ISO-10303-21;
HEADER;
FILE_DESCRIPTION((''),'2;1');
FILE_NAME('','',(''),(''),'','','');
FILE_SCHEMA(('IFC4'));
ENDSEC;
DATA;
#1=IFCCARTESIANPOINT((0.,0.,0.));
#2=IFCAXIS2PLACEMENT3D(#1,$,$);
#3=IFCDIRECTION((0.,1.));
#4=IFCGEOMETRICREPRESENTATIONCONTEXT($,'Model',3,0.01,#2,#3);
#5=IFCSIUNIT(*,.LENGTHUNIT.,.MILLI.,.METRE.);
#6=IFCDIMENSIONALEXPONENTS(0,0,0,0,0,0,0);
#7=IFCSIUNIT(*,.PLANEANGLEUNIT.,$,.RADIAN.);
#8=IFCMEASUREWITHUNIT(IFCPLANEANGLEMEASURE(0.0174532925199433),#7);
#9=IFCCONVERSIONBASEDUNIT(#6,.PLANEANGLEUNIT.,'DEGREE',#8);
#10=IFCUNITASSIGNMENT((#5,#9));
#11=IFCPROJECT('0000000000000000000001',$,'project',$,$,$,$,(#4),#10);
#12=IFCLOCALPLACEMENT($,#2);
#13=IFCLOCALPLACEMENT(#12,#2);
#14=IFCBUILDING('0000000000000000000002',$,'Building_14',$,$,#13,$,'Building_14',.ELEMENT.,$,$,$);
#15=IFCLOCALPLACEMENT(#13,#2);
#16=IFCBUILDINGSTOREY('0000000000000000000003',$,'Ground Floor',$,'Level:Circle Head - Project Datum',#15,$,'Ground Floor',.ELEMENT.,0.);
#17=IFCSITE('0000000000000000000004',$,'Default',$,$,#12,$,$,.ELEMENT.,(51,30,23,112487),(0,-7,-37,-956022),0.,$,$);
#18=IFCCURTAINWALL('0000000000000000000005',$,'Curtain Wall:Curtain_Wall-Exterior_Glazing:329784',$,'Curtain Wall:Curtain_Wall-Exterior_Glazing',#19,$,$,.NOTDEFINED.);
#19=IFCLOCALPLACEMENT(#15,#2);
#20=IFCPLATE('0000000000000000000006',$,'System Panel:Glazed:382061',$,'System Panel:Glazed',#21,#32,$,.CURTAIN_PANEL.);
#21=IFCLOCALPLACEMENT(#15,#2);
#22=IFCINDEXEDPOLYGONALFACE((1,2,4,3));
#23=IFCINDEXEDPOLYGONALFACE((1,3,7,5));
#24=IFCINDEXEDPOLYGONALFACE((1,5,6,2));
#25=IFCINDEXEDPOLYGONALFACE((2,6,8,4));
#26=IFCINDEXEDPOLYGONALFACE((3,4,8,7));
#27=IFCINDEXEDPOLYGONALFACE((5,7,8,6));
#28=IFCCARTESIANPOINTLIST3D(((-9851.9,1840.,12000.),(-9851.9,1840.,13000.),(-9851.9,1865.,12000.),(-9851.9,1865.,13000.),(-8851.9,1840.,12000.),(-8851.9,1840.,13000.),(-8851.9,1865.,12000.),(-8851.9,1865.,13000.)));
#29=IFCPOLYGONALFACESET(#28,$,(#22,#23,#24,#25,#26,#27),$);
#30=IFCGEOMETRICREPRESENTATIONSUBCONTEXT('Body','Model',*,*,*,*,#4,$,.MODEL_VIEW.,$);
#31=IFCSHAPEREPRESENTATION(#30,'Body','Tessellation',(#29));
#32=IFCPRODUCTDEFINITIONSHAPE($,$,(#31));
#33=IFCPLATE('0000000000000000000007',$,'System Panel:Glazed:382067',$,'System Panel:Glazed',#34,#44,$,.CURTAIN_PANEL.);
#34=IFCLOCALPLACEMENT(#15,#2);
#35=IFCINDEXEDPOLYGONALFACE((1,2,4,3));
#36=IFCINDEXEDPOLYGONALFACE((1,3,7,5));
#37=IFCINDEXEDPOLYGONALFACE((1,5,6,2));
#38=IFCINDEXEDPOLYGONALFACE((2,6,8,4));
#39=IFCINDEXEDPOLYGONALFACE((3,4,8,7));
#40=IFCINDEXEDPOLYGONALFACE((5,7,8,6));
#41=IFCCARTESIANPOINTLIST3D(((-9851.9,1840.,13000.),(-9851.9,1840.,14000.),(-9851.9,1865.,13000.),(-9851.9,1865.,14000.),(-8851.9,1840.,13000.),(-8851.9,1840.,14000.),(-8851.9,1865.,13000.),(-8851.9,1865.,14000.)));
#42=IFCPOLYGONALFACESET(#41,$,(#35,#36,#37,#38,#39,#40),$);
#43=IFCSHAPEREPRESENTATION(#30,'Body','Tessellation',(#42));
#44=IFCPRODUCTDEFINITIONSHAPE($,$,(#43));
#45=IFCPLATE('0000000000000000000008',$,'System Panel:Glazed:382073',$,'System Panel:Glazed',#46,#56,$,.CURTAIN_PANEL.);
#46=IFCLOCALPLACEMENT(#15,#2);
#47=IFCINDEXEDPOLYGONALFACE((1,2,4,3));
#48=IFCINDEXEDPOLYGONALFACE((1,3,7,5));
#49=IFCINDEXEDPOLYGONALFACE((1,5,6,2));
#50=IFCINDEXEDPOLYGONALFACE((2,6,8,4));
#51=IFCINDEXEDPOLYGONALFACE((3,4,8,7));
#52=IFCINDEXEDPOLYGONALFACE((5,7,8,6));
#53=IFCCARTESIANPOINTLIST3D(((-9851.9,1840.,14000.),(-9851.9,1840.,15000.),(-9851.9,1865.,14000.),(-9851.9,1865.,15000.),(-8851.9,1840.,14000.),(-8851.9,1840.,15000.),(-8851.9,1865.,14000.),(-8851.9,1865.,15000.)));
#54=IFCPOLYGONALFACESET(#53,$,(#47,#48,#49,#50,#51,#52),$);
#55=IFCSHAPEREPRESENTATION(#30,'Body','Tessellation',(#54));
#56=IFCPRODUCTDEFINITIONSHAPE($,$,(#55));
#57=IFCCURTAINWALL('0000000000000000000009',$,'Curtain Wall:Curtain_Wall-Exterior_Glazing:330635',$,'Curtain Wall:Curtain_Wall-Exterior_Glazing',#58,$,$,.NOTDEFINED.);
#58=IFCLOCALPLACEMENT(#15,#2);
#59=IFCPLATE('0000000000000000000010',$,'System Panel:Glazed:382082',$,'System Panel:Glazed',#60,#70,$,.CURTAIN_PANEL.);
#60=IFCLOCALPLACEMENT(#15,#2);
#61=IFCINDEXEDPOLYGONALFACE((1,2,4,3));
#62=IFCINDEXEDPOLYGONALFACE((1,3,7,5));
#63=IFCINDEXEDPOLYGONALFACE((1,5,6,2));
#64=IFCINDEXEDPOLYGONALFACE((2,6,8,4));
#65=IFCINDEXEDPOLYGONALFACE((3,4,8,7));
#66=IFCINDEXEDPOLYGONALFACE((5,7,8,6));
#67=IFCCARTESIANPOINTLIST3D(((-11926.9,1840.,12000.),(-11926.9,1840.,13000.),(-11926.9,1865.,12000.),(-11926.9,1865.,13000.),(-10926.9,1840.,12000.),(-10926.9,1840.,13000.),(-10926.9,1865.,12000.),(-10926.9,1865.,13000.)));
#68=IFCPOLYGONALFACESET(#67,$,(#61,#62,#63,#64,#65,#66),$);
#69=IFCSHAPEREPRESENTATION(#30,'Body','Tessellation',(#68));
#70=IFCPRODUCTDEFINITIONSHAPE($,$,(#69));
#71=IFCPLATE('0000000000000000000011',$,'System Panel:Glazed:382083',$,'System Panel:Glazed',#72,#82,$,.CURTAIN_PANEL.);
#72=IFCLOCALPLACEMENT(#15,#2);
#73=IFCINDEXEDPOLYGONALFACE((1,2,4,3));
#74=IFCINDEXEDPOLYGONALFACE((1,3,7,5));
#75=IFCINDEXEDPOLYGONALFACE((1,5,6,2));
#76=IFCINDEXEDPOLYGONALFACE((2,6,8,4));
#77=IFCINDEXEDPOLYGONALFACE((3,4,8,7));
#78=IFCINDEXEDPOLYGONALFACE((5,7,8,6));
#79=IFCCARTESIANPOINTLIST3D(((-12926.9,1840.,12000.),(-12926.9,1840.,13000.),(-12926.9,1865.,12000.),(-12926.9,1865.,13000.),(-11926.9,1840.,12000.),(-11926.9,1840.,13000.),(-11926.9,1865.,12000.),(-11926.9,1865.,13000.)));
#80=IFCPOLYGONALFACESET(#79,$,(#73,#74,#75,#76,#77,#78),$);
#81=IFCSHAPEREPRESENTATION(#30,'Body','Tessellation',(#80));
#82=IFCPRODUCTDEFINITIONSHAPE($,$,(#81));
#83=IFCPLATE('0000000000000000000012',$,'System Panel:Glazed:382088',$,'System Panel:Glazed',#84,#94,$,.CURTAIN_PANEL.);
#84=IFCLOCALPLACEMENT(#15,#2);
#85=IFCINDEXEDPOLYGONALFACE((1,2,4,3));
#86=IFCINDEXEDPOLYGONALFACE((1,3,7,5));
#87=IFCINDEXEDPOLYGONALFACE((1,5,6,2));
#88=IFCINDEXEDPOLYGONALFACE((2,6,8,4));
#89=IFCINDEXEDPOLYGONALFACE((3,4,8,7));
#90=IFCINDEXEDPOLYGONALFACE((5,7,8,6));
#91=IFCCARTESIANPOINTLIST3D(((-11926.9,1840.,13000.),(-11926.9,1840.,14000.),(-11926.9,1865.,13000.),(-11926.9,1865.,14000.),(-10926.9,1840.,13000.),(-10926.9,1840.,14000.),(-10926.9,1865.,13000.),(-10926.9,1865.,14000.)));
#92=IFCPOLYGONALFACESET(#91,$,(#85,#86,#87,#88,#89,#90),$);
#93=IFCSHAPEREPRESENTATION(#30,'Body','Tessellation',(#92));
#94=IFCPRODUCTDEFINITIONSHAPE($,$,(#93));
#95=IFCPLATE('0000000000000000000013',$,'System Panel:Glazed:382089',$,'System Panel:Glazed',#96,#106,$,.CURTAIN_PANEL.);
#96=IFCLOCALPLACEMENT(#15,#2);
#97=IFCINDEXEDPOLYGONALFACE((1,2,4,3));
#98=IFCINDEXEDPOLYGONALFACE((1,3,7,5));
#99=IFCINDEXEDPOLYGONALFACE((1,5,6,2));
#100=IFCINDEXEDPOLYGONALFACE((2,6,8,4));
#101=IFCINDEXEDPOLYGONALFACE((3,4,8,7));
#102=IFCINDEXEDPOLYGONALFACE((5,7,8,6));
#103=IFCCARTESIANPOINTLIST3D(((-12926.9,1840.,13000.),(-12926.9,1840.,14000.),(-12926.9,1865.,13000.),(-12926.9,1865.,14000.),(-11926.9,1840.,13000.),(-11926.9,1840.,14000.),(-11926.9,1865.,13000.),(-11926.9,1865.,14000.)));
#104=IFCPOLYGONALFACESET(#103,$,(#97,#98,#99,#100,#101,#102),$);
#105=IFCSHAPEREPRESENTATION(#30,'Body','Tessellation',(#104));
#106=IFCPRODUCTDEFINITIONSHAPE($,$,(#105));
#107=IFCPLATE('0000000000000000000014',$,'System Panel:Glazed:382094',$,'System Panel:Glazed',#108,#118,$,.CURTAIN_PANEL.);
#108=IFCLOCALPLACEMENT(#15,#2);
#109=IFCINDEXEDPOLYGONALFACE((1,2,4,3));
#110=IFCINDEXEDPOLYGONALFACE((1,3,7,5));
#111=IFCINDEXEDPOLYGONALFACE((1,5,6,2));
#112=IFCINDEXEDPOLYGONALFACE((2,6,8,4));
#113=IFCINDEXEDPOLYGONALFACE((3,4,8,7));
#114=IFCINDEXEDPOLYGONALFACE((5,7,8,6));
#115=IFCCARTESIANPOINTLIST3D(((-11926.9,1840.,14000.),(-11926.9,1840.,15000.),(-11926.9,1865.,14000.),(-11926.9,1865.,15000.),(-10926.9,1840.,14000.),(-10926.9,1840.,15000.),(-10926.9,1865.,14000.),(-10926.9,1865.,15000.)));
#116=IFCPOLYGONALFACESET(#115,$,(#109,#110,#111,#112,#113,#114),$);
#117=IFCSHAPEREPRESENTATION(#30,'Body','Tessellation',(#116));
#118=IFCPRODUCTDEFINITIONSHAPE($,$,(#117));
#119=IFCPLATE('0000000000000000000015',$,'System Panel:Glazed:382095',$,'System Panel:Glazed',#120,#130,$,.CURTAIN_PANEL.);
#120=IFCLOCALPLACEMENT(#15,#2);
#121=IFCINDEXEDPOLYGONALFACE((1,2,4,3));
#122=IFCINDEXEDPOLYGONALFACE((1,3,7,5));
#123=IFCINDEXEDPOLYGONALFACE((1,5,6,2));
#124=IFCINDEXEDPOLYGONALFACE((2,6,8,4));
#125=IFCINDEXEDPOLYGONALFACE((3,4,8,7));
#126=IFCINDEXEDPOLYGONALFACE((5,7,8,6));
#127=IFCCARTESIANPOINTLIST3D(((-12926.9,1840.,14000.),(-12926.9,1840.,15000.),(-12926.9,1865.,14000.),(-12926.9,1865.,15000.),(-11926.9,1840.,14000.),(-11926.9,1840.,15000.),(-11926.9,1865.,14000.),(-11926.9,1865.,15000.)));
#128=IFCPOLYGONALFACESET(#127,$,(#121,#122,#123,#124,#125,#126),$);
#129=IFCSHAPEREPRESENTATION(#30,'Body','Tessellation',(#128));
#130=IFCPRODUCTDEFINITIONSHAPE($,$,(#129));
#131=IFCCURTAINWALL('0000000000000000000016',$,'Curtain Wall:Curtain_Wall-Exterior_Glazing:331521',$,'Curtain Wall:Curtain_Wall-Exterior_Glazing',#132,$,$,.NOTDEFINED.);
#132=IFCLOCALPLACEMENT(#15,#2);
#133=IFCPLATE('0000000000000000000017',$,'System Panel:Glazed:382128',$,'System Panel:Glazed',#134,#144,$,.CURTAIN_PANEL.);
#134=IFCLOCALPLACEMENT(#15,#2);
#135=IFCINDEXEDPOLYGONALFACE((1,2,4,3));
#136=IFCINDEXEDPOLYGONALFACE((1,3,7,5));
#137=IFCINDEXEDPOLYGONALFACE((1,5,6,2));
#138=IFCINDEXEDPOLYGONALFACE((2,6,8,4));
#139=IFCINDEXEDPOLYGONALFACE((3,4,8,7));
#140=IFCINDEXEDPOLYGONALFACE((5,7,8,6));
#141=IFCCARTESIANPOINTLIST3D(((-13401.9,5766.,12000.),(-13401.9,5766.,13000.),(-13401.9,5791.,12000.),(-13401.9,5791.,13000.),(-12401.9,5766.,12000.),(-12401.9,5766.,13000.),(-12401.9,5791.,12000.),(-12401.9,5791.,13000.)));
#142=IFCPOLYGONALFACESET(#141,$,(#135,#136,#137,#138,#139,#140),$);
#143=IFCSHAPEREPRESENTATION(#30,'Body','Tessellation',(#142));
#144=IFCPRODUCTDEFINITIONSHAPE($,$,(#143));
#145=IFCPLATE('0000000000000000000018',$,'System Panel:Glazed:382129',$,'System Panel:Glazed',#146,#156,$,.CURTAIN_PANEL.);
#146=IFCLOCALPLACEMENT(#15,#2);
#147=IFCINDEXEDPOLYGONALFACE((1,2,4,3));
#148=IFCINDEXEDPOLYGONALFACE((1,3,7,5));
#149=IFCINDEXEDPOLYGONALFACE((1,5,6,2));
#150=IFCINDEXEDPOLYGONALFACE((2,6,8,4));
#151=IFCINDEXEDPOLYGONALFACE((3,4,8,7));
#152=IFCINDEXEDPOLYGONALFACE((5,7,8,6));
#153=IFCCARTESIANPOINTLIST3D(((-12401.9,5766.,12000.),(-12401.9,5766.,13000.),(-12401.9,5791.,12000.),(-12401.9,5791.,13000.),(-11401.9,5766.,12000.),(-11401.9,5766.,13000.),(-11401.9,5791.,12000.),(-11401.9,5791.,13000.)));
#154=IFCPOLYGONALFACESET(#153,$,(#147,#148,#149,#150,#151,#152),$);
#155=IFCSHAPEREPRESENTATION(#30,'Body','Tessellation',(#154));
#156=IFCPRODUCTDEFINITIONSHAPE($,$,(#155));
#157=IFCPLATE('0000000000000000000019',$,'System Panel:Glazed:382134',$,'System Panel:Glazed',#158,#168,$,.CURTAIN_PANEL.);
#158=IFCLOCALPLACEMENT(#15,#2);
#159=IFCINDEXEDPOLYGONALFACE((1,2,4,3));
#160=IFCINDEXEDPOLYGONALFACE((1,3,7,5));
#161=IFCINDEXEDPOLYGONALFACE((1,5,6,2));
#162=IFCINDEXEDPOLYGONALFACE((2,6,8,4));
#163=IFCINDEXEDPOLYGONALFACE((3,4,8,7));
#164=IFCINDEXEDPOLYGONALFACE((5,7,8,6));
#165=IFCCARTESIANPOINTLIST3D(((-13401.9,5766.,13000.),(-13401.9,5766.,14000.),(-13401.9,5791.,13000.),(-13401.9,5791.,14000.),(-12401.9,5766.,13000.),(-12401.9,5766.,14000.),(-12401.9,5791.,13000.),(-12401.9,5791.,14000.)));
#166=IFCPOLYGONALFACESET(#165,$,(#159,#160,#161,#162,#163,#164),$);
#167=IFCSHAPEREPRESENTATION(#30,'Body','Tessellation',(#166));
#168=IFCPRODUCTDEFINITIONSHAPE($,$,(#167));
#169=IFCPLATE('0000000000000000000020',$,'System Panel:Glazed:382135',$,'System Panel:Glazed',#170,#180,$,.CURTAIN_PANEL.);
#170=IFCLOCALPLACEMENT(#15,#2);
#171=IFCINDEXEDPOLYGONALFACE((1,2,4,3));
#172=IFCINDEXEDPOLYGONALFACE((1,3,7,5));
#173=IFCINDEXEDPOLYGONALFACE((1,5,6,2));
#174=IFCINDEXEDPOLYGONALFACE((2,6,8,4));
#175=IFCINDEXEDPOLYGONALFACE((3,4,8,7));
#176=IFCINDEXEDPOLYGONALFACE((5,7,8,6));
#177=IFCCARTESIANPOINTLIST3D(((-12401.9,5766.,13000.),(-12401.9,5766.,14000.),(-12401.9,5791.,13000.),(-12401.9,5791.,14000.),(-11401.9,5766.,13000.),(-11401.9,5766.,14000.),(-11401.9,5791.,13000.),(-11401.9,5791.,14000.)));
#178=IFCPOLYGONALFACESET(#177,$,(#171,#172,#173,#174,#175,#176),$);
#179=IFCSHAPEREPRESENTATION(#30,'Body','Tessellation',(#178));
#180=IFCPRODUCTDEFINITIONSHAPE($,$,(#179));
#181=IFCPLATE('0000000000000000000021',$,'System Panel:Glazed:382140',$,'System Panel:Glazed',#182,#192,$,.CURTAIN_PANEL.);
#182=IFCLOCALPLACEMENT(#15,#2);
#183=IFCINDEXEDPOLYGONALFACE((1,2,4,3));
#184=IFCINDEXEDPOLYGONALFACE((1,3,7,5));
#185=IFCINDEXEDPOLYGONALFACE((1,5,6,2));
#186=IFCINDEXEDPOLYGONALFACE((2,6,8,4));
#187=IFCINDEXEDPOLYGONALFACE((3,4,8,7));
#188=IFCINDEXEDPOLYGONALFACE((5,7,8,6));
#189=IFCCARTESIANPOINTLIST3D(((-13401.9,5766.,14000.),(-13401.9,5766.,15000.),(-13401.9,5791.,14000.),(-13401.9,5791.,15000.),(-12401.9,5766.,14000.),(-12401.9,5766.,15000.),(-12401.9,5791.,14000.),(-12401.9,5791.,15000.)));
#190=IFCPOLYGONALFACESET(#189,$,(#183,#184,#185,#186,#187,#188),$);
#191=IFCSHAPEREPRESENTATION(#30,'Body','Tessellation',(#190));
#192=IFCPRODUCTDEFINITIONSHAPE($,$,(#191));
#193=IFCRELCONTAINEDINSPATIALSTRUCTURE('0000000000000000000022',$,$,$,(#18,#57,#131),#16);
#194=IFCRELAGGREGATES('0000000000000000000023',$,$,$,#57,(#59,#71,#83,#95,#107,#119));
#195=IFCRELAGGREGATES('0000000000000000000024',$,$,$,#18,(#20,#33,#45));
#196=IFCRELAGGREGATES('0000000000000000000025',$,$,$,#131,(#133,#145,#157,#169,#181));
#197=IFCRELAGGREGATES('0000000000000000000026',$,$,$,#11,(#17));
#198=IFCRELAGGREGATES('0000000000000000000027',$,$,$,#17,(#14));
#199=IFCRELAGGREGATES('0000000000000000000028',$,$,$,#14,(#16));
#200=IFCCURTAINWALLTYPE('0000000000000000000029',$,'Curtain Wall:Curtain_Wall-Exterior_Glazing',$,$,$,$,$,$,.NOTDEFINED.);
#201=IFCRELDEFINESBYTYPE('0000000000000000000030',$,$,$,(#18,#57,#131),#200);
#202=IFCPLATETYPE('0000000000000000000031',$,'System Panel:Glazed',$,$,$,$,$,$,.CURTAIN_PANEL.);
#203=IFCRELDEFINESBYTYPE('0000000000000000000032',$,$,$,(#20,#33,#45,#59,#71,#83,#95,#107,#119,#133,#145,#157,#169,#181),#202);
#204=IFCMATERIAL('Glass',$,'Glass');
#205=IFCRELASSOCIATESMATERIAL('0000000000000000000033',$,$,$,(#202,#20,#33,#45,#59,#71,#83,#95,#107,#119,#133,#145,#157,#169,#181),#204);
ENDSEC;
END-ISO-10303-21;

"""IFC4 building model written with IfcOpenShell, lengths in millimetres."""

from ifc_helpers import new_model, entity, si_unit, converted_unit, direction, frame, origin, place, context, subcontext, project, spatial, indexed_curve, outline, extrude, source, transform, mapped, material, type_object, type_shapes, element, aggregate, save


model = new_model("IFC4")

# Units and contexts
model_context = context("Model", 3, precision=0.01, world=origin(), true_north=direction((0.0, 1.0)))
body_context = subcontext(model_context, "Body", "Model", "MODEL_VIEW")
ifc_project = project(units=[si_unit("LENGTHUNIT", "METRE", prefix="MILLI"), converted_unit("PLANEANGLEUNIT", "DEGREE", entity("IfcPlaneAngleMeasure", 0.0174532925199433), si_unit("PLANEANGLEUNIT", "RADIAN"), dimensions=[0, 0, 0, 0, 0, 0, 0])], contexts=[model_context])

# Site, building, storey
site_placement = place(None, origin())
site = spatial("IfcSite", under=ifc_project, at=site_placement, Name="Default", CompositionType="ELEMENT", RefLatitude=(51, 30, 23, 112487), RefLongitude=(0, -7, -37, -956022), RefElevation=0.0)
building_placement = place(site_placement, origin())
building = spatial("IfcBuilding", under=site, at=building_placement, Name="Building_14", LongName="Building_14", CompositionType="ELEMENT")
storey_placement = place(building_placement, origin())
storey = spatial("IfcBuildingStorey", under=building, at=storey_placement, Name="Ground Floor", ObjectType="Level:Circle Head - Project Datum", LongName="Ground Floor", CompositionType="ELEMENT", Elevation=0.0)

# Curtain walls, plates
curtain_wall_type = type_object("IfcCurtainWallType", Name="Curtain Wall:Curtain_Wall-Exterior_Glazing", PredefinedType="NOTDEFINED")
curtain_wall_1_placement = place(storey_placement, origin())
curtain_wall_1 = element("IfcCurtainWall", 1, at=curtain_wall_1_placement, inside=storey, type_object=curtain_wall_type, Name="Curtain Wall:Curtain_Wall-Exterior_Glazing:329784", ObjectType="Curtain Wall:Curtain_Wall-Exterior_Glazing", PredefinedType="NOTDEFINED")
ifc_material = material(Name="Glass", Category="Glass")
plate_type_1 = type_object("IfcPlateType", Name="System Panel:Glazed", PredefinedType="CURTAIN_PANEL", material=ifc_material)
shared_shape_1 = source(origin(), body_context, "Body", "SweptSolid", [
    extrude(outline(indexed_curve([(-12.5, -500.0), (12.5, -500.0), (12.5, 500.0), (-12.5, 500.0), (-12.5, -500.0)], self_intersect=False)), frame((0.0, -37.0, 0.0), z_axis=(0.0, 0.0, 1.0), x_axis=(0.0, 1.0, 0.0)), (0.0, 0.0, 1.0), 1000.0),
])
type_shapes(plate_type_1, [shared_shape_1])
plate_1_placement = place(curtain_wall_1_placement, frame((-9351.9, 1815.5, 12000.0), z_axis=(0.0, 0.0, 1.0), x_axis=(-1.0, 0.0, 0.0)))
plate_1 = element("IfcPlate", 2, at=plate_1_placement, type_object=plate_type_1, material=ifc_material, Name="System Panel:Glazed:382061", ObjectType="System Panel:Glazed", PredefinedType="CURTAIN_PANEL", context=body_context, shape_type="MappedRepresentation", body=[
    mapped(shared_shape_1, transform((0.0, 0.0, 0.0), scale=1.0)),
])
plate_2_placement = place(curtain_wall_1_placement, frame((-9351.9, 1815.5, 13000.0), z_axis=(0.0, 0.0, 1.0), x_axis=(-1.0, 0.0, 0.0)))
plate_2 = element("IfcPlate", 3, at=plate_2_placement, type_object=plate_type_1, material=ifc_material, Name="System Panel:Glazed:382067", ObjectType="System Panel:Glazed", PredefinedType="CURTAIN_PANEL", context=body_context, shape_type="MappedRepresentation", body=[
    mapped(shared_shape_1, transform((0.0, 0.0, 0.0), scale=1.0)),
])
plate_3_placement = place(curtain_wall_1_placement, frame((-9351.9, 1815.5, 14000.0), z_axis=(0.0, 0.0, 1.0), x_axis=(-1.0, 0.0, 0.0)))
plate_3 = element("IfcPlate", 4, at=plate_3_placement, type_object=plate_type_1, material=ifc_material, Name="System Panel:Glazed:382073", ObjectType="System Panel:Glazed", PredefinedType="CURTAIN_PANEL", context=body_context, shape_type="MappedRepresentation", body=[
    mapped(shared_shape_1, transform((0.0, 0.0, 0.0), scale=1.0)),
])
curtain_wall_2_placement = place(storey_placement, origin())
curtain_wall_2 = element("IfcCurtainWall", 5, at=curtain_wall_2_placement, inside=storey, type_object=curtain_wall_type, Name="Curtain Wall:Curtain_Wall-Exterior_Glazing:330635", ObjectType="Curtain Wall:Curtain_Wall-Exterior_Glazing", PredefinedType="NOTDEFINED")
plate_4_placement = place(curtain_wall_2_placement, frame((-11426.9, 1815.5, 12000.0), z_axis=(0.0, 0.0, 1.0), x_axis=(-1.0, 0.0, 0.0)))
plate_4 = element("IfcPlate", 6, at=plate_4_placement, type_object=plate_type_1, material=ifc_material, Name="System Panel:Glazed:382082", ObjectType="System Panel:Glazed", PredefinedType="CURTAIN_PANEL", context=body_context, shape_type="MappedRepresentation", body=[
    mapped(shared_shape_1, transform((0.0, 0.0, 0.0), scale=1.0)),
])
plate_5_placement = place(curtain_wall_2_placement, frame((-12426.9, 1815.5, 12000.0), z_axis=(0.0, 0.0, 1.0), x_axis=(-1.0, 0.0, 0.0)))
plate_5 = element("IfcPlate", 7, at=plate_5_placement, type_object=plate_type_1, material=ifc_material, Name="System Panel:Glazed:382083", ObjectType="System Panel:Glazed", PredefinedType="CURTAIN_PANEL", context=body_context, shape_type="MappedRepresentation", body=[
    mapped(shared_shape_1, transform((0.0, 0.0, 0.0), scale=1.0)),
])
plate_6_placement = place(curtain_wall_2_placement, frame((-11426.9, 1815.5, 13000.0), z_axis=(0.0, 0.0, 1.0), x_axis=(-1.0, 0.0, 0.0)))
plate_6 = element("IfcPlate", 8, at=plate_6_placement, type_object=plate_type_1, material=ifc_material, Name="System Panel:Glazed:382088", ObjectType="System Panel:Glazed", PredefinedType="CURTAIN_PANEL", context=body_context, shape_type="MappedRepresentation", body=[
    mapped(shared_shape_1, transform((0.0, 0.0, 0.0), scale=1.0)),
])
plate_7_placement = place(curtain_wall_2_placement, frame((-12426.9, 1815.5, 13000.0), z_axis=(0.0, 0.0, 1.0), x_axis=(-1.0, 0.0, 0.0)))
plate_7 = element("IfcPlate", 9, at=plate_7_placement, type_object=plate_type_1, material=ifc_material, Name="System Panel:Glazed:382089", ObjectType="System Panel:Glazed", PredefinedType="CURTAIN_PANEL", context=body_context, shape_type="MappedRepresentation", body=[
    mapped(shared_shape_1, transform((0.0, 0.0, 0.0), scale=1.0)),
])
plate_8_placement = place(curtain_wall_2_placement, frame((-11426.9, 1815.5, 14000.0), z_axis=(0.0, 0.0, 1.0), x_axis=(-1.0, 0.0, 0.0)))
plate_8 = element("IfcPlate", 10, at=plate_8_placement, type_object=plate_type_1, material=ifc_material, Name="System Panel:Glazed:382094", ObjectType="System Panel:Glazed", PredefinedType="CURTAIN_PANEL", context=body_context, shape_type="MappedRepresentation", body=[
    mapped(shared_shape_1, transform((0.0, 0.0, 0.0), scale=1.0)),
])
plate_9_placement = place(curtain_wall_2_placement, frame((-12426.9, 1815.5, 14000.0), z_axis=(0.0, 0.0, 1.0), x_axis=(-1.0, 0.0, 0.0)))
plate_9 = element("IfcPlate", 11, at=plate_9_placement, type_object=plate_type_1, material=ifc_material, Name="System Panel:Glazed:382095", ObjectType="System Panel:Glazed", PredefinedType="CURTAIN_PANEL", context=body_context, shape_type="MappedRepresentation", body=[
    mapped(shared_shape_1, transform((0.0, 0.0, 0.0), scale=1.0)),
])
curtain_wall_3_placement = place(storey_placement, origin())
curtain_wall_3 = element("IfcCurtainWall", 12, at=curtain_wall_3_placement, inside=storey, type_object=curtain_wall_type, Name="Curtain Wall:Curtain_Wall-Exterior_Glazing:331521", ObjectType="Curtain Wall:Curtain_Wall-Exterior_Glazing", PredefinedType="NOTDEFINED")
plate_10_placement = place(curtain_wall_3_placement, frame((-12901.9, 5815.5, 12000.0)))
plate_10 = element("IfcPlate", 13, at=plate_10_placement, type_object=plate_type_1, material=ifc_material, Name="System Panel:Glazed:382128", ObjectType="System Panel:Glazed", PredefinedType="CURTAIN_PANEL", context=body_context, shape_type="MappedRepresentation", body=[
    mapped(shared_shape_1, transform((0.0, 0.0, 0.0), scale=1.0)),
])
plate_11_placement = place(curtain_wall_3_placement, frame((-11901.9, 5815.5, 12000.0)))
plate_11 = element("IfcPlate", 14, at=plate_11_placement, type_object=plate_type_1, material=ifc_material, Name="System Panel:Glazed:382129", ObjectType="System Panel:Glazed", PredefinedType="CURTAIN_PANEL", context=body_context, shape_type="MappedRepresentation", body=[
    mapped(shared_shape_1, transform((0.0, 0.0, 0.0), scale=1.0)),
])
plate_12_placement = place(curtain_wall_3_placement, frame((-12901.9, 5815.5, 13000.0)))
plate_12 = element("IfcPlate", 15, at=plate_12_placement, type_object=plate_type_1, material=ifc_material, Name="System Panel:Glazed:382134", ObjectType="System Panel:Glazed", PredefinedType="CURTAIN_PANEL", context=body_context, shape_type="MappedRepresentation", body=[
    mapped(shared_shape_1, transform((0.0, 0.0, 0.0), scale=1.0)),
])
plate_13_placement = place(curtain_wall_3_placement, frame((-11901.9, 5815.5, 13000.0)))
plate_13 = element("IfcPlate", 16, at=plate_13_placement, type_object=plate_type_1, material=ifc_material, Name="System Panel:Glazed:382135", ObjectType="System Panel:Glazed", PredefinedType="CURTAIN_PANEL", context=body_context, shape_type="MappedRepresentation", body=[
    mapped(shared_shape_1, transform((0.0, 0.0, 0.0), scale=1.0)),
])
plate_14_placement = place(curtain_wall_3_placement, frame((-12901.9, 5815.5, 14000.0)))
plate_14 = element("IfcPlate", 17, at=plate_14_placement, type_object=plate_type_1, material=ifc_material, Name="System Panel:Glazed:382140", ObjectType="System Panel:Glazed", PredefinedType="CURTAIN_PANEL", context=body_context, shape_type="MappedRepresentation", body=[
    mapped(shared_shape_1, transform((0.0, 0.0, 0.0), scale=1.0)),
])

aggregate(curtain_wall_2, [plate_4, plate_5, plate_6, plate_7, plate_8, plate_9])
aggregate(curtain_wall_1, [plate_1, plate_2, plate_3])
aggregate(curtain_wall_3, [plate_10, plate_11, plate_12, plate_13, plate_14])

save(model, "model.ifc")
